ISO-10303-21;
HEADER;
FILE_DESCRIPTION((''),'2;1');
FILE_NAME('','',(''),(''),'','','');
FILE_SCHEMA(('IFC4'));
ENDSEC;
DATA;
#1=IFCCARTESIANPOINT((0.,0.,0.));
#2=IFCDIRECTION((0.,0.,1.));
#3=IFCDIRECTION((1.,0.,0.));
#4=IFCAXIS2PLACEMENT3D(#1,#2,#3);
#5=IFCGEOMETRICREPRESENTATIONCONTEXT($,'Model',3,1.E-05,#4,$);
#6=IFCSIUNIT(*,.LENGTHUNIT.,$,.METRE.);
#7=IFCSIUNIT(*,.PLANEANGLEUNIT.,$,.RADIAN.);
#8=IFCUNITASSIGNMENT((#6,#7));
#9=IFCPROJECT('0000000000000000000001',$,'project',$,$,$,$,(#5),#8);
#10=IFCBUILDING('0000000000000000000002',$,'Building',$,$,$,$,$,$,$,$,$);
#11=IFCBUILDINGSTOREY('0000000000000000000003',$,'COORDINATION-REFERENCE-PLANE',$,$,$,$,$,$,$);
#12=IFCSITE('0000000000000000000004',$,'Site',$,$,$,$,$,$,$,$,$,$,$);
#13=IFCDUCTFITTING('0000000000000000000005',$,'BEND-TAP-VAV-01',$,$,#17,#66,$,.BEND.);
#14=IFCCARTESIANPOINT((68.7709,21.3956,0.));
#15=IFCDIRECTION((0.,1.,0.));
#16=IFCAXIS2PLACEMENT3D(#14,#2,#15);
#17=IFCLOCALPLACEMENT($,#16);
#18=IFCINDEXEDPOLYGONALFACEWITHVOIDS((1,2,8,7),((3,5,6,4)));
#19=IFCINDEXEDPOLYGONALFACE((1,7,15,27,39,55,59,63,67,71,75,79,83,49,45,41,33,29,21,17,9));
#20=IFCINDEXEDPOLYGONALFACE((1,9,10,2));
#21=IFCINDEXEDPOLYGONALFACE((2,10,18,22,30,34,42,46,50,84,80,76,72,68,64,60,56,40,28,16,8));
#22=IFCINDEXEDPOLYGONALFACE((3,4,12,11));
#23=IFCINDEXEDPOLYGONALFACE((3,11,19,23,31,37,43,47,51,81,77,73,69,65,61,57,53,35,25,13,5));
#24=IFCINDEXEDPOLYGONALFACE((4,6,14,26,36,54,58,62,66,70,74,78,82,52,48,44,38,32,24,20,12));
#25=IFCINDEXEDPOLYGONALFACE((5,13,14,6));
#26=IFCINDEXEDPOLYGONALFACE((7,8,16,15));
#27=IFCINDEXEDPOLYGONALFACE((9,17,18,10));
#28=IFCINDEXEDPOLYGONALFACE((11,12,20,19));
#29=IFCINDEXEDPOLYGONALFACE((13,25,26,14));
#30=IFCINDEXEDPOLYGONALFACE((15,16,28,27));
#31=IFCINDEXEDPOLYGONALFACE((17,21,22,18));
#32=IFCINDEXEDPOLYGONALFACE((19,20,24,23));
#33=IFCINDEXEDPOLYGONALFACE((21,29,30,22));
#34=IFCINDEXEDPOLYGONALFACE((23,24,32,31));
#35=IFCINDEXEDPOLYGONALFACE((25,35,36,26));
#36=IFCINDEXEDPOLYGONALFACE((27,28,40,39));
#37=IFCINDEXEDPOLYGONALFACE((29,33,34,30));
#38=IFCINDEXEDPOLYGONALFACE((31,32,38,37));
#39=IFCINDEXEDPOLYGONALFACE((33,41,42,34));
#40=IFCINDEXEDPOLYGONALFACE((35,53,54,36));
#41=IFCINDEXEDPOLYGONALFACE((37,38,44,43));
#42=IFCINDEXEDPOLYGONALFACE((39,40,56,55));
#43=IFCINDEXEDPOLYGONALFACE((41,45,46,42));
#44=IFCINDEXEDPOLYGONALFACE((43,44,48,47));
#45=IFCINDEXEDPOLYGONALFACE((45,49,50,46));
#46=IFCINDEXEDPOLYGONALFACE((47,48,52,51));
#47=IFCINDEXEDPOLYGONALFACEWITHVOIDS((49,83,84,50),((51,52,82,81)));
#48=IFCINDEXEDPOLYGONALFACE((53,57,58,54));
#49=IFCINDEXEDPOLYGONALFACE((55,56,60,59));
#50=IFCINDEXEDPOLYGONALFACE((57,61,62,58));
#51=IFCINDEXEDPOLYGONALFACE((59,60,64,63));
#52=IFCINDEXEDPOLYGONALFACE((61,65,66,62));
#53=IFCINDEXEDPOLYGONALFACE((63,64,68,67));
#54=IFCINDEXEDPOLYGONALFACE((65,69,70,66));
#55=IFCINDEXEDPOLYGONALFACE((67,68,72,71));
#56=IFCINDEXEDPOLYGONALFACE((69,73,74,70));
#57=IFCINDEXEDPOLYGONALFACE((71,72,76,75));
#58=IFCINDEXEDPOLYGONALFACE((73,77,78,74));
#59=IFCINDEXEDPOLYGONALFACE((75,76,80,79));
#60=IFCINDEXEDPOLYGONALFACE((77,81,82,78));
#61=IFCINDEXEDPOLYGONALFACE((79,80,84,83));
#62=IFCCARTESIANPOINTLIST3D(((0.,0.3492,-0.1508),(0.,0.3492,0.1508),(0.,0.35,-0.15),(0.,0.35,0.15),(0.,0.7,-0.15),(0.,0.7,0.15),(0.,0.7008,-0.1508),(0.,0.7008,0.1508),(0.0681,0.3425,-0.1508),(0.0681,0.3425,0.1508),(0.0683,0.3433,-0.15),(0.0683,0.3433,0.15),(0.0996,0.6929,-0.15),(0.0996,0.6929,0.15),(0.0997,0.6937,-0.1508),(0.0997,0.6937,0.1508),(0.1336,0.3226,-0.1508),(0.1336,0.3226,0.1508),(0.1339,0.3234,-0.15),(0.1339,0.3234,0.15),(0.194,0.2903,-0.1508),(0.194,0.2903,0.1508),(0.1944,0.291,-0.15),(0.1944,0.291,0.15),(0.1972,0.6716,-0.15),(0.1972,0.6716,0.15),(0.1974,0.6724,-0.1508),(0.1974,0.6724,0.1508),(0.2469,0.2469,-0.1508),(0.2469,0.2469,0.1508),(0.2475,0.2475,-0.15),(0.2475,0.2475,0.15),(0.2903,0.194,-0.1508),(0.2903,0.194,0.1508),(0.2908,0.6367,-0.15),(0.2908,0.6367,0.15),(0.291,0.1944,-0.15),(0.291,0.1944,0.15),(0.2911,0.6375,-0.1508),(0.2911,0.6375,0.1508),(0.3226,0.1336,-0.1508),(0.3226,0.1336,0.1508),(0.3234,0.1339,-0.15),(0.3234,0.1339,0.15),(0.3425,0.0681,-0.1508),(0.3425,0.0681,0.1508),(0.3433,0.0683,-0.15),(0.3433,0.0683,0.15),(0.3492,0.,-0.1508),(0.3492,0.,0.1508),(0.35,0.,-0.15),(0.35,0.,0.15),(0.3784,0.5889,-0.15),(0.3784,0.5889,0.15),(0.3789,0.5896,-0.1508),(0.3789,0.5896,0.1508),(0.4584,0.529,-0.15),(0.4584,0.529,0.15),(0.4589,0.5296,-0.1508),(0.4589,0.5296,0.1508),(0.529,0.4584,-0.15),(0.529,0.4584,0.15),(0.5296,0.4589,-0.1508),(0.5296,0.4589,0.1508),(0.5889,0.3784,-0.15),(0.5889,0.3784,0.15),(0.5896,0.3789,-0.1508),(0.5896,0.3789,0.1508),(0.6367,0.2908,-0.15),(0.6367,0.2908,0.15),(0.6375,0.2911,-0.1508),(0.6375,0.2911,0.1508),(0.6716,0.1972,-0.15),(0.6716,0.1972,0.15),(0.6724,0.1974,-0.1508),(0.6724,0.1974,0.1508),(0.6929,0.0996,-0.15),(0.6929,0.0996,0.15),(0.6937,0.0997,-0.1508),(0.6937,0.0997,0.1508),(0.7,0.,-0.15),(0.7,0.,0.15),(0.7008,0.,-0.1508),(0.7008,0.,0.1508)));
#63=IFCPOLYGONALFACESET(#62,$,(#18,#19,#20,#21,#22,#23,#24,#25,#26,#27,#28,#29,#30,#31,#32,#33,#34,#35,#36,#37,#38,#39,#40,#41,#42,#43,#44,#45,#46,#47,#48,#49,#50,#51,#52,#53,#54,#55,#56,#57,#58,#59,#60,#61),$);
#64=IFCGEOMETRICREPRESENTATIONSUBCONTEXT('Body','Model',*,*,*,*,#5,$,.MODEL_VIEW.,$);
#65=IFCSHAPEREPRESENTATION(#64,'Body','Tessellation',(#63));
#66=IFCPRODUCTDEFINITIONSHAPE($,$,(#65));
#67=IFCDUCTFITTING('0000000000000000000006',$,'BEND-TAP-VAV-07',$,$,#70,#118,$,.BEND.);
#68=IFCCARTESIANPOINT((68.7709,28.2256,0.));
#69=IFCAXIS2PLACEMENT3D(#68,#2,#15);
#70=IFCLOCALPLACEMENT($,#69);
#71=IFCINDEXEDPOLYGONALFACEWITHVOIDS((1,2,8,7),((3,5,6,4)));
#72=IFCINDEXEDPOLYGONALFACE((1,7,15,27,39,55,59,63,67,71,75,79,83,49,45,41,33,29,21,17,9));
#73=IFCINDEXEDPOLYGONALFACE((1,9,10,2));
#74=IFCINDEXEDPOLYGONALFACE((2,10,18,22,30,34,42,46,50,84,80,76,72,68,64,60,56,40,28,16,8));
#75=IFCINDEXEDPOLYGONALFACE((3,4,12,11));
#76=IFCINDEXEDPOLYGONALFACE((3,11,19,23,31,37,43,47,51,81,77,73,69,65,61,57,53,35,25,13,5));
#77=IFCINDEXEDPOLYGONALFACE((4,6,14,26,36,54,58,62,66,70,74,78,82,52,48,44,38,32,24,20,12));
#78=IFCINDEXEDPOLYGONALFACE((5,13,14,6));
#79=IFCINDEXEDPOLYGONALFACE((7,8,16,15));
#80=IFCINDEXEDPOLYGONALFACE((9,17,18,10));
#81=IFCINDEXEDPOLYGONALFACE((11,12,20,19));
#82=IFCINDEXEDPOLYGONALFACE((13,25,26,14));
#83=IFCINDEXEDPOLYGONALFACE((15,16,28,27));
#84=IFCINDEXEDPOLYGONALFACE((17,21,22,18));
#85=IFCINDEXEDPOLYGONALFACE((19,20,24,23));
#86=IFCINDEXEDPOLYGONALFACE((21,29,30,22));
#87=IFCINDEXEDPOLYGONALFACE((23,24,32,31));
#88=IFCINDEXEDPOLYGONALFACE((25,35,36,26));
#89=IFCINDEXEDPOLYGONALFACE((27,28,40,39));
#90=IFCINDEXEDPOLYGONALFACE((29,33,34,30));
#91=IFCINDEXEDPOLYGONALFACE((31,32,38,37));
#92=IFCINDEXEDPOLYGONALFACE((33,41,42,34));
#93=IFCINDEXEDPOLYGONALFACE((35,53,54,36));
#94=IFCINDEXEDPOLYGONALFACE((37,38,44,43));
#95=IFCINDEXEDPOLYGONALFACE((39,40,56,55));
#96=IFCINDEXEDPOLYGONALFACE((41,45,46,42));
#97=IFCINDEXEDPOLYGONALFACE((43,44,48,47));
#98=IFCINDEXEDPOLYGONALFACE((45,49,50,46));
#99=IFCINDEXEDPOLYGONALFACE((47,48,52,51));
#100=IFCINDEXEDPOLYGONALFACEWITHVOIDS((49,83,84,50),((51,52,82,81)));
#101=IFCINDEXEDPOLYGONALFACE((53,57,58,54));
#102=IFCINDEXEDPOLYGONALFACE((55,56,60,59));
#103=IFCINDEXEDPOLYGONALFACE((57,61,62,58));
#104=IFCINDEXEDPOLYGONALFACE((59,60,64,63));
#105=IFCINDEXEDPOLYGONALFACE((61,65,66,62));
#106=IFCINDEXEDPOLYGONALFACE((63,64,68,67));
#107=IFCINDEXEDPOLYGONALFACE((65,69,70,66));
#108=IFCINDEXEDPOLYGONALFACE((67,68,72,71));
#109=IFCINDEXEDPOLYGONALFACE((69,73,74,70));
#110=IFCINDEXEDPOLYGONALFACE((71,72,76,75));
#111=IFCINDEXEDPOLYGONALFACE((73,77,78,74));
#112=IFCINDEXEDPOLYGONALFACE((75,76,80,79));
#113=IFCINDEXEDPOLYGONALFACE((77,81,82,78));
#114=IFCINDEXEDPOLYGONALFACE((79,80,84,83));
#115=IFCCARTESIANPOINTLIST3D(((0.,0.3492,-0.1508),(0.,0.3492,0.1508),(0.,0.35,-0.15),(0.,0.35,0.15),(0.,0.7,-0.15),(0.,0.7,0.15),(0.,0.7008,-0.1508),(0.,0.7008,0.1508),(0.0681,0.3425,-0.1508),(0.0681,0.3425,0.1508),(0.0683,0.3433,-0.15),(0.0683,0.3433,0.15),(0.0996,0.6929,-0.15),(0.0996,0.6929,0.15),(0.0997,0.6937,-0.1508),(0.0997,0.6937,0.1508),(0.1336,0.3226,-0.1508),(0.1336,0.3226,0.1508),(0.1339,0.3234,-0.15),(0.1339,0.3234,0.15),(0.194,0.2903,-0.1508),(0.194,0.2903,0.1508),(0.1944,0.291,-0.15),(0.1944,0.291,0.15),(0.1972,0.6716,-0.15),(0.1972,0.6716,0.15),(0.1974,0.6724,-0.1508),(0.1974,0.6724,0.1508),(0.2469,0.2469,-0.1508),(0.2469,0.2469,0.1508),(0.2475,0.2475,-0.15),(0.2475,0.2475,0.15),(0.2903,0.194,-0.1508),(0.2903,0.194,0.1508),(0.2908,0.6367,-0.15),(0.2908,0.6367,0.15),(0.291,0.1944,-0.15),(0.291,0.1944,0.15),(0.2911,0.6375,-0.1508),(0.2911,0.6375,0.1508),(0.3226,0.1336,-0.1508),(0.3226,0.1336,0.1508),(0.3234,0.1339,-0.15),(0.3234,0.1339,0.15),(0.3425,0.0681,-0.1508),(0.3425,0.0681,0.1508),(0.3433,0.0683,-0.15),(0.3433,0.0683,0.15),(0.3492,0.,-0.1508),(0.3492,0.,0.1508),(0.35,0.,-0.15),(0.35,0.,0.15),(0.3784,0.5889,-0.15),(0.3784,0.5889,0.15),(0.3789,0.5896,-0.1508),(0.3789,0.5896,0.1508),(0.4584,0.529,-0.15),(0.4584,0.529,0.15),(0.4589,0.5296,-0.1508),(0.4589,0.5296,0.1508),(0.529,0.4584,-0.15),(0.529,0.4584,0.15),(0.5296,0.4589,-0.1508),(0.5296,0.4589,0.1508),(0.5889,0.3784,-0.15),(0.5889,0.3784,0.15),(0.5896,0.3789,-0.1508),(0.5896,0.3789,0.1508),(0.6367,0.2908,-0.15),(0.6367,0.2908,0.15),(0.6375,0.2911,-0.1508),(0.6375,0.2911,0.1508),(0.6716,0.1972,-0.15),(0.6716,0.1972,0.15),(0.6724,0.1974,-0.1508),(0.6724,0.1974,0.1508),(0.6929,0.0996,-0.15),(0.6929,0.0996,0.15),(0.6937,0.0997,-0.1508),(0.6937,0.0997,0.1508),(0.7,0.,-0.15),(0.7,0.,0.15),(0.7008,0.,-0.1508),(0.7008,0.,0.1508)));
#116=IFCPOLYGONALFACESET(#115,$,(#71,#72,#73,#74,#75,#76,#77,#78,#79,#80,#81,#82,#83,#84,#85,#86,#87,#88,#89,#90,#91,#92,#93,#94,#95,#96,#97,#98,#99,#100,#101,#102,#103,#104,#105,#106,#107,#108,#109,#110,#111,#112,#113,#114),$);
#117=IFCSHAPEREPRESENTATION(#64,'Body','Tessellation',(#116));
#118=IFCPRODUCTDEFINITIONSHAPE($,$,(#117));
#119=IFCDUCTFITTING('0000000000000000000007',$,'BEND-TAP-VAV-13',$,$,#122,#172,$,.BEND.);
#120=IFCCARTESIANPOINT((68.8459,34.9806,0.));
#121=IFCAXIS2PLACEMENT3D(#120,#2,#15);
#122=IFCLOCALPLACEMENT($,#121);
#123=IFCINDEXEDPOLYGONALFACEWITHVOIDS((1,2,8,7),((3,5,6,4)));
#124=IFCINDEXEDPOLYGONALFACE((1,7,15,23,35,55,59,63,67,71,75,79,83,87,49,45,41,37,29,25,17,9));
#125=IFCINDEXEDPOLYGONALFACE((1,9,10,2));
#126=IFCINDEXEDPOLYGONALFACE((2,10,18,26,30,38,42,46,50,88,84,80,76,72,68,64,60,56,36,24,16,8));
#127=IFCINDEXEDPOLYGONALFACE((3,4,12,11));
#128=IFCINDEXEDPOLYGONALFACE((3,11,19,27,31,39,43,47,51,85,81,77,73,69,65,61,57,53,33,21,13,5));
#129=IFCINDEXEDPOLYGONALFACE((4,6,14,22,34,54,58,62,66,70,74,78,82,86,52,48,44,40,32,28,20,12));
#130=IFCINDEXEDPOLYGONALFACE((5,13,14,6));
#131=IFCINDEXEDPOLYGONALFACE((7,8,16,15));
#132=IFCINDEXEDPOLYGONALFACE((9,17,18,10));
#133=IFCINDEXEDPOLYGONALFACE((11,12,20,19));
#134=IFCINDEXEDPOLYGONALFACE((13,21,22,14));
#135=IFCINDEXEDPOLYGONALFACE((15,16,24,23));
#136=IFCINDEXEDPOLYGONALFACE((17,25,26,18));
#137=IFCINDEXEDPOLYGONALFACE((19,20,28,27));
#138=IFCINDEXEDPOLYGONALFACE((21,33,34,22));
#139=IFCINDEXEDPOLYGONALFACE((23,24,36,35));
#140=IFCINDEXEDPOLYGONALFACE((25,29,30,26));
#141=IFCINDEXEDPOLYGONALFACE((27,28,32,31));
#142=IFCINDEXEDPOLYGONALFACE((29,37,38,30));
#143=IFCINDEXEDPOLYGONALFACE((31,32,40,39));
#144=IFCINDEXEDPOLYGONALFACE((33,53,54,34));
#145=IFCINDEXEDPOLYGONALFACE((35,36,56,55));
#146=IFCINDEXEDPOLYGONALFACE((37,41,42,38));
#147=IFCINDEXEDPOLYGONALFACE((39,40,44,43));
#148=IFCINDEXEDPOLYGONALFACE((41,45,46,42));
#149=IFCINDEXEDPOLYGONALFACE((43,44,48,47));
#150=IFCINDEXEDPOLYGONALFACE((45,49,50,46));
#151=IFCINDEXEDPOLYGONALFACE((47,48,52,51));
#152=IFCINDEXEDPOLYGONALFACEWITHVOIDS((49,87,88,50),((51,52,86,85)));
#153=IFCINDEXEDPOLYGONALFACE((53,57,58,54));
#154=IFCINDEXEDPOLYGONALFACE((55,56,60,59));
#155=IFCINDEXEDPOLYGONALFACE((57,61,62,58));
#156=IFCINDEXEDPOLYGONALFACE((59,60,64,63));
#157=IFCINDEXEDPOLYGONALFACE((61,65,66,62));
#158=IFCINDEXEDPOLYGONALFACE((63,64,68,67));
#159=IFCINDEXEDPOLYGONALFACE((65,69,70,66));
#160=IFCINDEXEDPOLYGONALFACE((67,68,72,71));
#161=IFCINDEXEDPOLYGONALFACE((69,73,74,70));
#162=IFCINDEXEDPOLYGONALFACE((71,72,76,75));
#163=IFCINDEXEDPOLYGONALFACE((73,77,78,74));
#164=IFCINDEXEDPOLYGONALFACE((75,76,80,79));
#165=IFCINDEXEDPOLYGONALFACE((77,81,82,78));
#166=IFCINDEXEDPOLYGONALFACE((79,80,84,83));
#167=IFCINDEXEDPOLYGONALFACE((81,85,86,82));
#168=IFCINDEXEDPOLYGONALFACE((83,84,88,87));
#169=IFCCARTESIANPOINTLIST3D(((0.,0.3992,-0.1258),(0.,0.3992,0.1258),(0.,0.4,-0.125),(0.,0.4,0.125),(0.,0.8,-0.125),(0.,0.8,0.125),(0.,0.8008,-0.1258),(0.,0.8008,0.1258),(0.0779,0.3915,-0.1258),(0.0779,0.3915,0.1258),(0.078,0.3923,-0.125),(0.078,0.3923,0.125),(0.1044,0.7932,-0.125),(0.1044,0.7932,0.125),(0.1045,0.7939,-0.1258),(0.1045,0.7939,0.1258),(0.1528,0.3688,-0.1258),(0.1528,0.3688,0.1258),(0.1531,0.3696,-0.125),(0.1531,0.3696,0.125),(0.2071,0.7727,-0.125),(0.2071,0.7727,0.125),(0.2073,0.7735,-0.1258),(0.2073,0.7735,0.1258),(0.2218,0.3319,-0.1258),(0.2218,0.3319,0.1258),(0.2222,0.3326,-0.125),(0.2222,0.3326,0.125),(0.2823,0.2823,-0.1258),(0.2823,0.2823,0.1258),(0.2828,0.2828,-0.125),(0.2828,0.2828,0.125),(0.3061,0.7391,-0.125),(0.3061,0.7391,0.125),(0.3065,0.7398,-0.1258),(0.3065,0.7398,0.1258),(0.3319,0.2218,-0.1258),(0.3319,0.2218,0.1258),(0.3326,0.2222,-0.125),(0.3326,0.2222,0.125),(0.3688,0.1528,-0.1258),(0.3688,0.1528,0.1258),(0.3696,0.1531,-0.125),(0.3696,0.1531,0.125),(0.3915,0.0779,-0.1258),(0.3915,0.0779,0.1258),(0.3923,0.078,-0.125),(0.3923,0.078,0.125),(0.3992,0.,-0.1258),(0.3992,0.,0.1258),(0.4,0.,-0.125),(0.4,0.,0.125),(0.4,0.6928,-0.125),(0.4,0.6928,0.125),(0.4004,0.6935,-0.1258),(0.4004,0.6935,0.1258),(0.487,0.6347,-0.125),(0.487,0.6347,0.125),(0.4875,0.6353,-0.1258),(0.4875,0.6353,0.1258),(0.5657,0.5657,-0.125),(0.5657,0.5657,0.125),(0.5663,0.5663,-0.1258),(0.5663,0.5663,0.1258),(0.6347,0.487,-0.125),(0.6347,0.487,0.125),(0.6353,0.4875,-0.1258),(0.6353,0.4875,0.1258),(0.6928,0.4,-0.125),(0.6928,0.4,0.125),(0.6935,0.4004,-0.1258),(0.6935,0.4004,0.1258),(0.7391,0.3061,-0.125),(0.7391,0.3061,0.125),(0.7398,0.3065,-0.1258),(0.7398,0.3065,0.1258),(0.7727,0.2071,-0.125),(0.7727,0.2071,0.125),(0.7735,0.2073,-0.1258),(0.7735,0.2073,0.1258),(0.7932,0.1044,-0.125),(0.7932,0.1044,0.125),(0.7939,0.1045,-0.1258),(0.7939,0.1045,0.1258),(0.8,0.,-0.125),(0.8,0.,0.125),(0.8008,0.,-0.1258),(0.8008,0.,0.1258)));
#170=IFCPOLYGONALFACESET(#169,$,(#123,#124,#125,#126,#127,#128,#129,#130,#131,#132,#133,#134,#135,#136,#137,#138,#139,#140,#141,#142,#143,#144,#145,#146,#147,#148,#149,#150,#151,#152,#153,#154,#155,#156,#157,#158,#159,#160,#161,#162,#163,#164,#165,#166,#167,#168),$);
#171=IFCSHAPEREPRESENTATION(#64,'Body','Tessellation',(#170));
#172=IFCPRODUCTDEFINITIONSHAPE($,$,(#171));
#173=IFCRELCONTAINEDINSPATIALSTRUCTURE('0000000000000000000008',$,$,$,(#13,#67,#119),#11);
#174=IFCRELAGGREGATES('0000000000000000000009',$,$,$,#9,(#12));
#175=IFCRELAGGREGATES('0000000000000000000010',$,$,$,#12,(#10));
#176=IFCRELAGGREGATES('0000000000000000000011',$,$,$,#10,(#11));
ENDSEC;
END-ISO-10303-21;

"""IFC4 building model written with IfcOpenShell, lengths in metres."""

from ifc_helpers import new_model, entity, si_unit, frame, origin_with_axes, place, context, subcontext, project, spatial, element, save


model = new_model("IFC4")

# Units and contexts
model_context = context("Model", 3, precision=1e-05, world=origin_with_axes())
body_context_1 = subcontext(model_context, "Body", "Model", "MODEL_VIEW")
ifc_project = project(units=[si_unit("LENGTHUNIT", "METRE"), si_unit("PLANEANGLEUNIT", "RADIAN")], contexts=[model_context])

# Site, building, storey
site = spatial("IfcSite", under=ifc_project, Name="Site")
building = spatial("IfcBuilding", under=site, Name="Building")
storey = spatial("IfcBuildingStorey", under=building, Name="COORDINATION-REFERENCE-PLANE")

# Duct fittings
duct_fitting_1_placement = place(None, frame((68.7709, 21.3956, 0.0), z_axis=(0.0, 0.0, 1.0), x_axis=(0.0, 1.0, 0.0)))
cartesian_point_1 = entity("IfcCartesianPoint", [0.0, 0.0, 0.0])
element("IfcDuctFitting", 1, at=duct_fitting_1_placement, inside=storey, Name="BEND-TAP-VAV-01", PredefinedType="BEND", context=body_context_1, shape_type="SweptSolid", body=[
    entity("IfcRevolvedAreaSolid", entity("IfcRectangleHollowProfileDef", "AREA", None, entity("IfcAxis2Placement2D", entity("IfcCartesianPoint", [0.525, 0.0])), 0.3516, 0.3016, 0.0008), entity("IfcAxis2Placement3D", cartesian_point_1, entity("IfcDirection", [0.0, -1.0, 0.0]), entity("IfcDirection", [1.0, 0.0, 0.0])), entity("IfcAxis1Placement", cartesian_point_1, entity("IfcDirection", [0.0, 1.0, 0.0])), 1.570796),
])
duct_fitting_2_placement = place(None, frame((68.7709, 28.2256, 0.0), z_axis=(0.0, 0.0, 1.0), x_axis=(0.0, 1.0, 0.0)))
cartesian_point_2 = entity("IfcCartesianPoint", [0.0, 0.0, 0.0])
element("IfcDuctFitting", 2, at=duct_fitting_2_placement, inside=storey, Name="BEND-TAP-VAV-07", PredefinedType="BEND", context=body_context_1, shape_type="SweptSolid", body=[
    entity("IfcRevolvedAreaSolid", entity("IfcRectangleHollowProfileDef", "AREA", None, entity("IfcAxis2Placement2D", entity("IfcCartesianPoint", [0.525, 0.0])), 0.3516, 0.3016, 0.0008), entity("IfcAxis2Placement3D", cartesian_point_2, entity("IfcDirection", [0.0, -1.0, 0.0]), entity("IfcDirection", [1.0, 0.0, 0.0])), entity("IfcAxis1Placement", cartesian_point_2, entity("IfcDirection", [0.0, 1.0, 0.0])), 1.570796),
])
duct_fitting_3_placement = place(None, frame((68.8459, 34.9806, 0.0), z_axis=(0.0, 0.0, 1.0), x_axis=(0.0, 1.0, 0.0)))
cartesian_point_3 = entity("IfcCartesianPoint", [0.0, 0.0, 0.0])
element("IfcDuctFitting", 3, at=duct_fitting_3_placement, inside=storey, Name="BEND-TAP-VAV-13", PredefinedType="BEND", context=body_context_1, shape_type="SweptSolid", body=[
    entity("IfcRevolvedAreaSolid", entity("IfcRectangleHollowProfileDef", "AREA", None, entity("IfcAxis2Placement2D", entity("IfcCartesianPoint", [0.6, 0.0])), 0.4016, 0.2516, 0.0008), entity("IfcAxis2Placement3D", cartesian_point_3, entity("IfcDirection", [0.0, -1.0, 0.0]), entity("IfcDirection", [1.0, 0.0, 0.0])), entity("IfcAxis1Placement", cartesian_point_3, entity("IfcDirection", [0.0, 1.0, 0.0])), 1.570796),
])

save(model, "model.ifc")
